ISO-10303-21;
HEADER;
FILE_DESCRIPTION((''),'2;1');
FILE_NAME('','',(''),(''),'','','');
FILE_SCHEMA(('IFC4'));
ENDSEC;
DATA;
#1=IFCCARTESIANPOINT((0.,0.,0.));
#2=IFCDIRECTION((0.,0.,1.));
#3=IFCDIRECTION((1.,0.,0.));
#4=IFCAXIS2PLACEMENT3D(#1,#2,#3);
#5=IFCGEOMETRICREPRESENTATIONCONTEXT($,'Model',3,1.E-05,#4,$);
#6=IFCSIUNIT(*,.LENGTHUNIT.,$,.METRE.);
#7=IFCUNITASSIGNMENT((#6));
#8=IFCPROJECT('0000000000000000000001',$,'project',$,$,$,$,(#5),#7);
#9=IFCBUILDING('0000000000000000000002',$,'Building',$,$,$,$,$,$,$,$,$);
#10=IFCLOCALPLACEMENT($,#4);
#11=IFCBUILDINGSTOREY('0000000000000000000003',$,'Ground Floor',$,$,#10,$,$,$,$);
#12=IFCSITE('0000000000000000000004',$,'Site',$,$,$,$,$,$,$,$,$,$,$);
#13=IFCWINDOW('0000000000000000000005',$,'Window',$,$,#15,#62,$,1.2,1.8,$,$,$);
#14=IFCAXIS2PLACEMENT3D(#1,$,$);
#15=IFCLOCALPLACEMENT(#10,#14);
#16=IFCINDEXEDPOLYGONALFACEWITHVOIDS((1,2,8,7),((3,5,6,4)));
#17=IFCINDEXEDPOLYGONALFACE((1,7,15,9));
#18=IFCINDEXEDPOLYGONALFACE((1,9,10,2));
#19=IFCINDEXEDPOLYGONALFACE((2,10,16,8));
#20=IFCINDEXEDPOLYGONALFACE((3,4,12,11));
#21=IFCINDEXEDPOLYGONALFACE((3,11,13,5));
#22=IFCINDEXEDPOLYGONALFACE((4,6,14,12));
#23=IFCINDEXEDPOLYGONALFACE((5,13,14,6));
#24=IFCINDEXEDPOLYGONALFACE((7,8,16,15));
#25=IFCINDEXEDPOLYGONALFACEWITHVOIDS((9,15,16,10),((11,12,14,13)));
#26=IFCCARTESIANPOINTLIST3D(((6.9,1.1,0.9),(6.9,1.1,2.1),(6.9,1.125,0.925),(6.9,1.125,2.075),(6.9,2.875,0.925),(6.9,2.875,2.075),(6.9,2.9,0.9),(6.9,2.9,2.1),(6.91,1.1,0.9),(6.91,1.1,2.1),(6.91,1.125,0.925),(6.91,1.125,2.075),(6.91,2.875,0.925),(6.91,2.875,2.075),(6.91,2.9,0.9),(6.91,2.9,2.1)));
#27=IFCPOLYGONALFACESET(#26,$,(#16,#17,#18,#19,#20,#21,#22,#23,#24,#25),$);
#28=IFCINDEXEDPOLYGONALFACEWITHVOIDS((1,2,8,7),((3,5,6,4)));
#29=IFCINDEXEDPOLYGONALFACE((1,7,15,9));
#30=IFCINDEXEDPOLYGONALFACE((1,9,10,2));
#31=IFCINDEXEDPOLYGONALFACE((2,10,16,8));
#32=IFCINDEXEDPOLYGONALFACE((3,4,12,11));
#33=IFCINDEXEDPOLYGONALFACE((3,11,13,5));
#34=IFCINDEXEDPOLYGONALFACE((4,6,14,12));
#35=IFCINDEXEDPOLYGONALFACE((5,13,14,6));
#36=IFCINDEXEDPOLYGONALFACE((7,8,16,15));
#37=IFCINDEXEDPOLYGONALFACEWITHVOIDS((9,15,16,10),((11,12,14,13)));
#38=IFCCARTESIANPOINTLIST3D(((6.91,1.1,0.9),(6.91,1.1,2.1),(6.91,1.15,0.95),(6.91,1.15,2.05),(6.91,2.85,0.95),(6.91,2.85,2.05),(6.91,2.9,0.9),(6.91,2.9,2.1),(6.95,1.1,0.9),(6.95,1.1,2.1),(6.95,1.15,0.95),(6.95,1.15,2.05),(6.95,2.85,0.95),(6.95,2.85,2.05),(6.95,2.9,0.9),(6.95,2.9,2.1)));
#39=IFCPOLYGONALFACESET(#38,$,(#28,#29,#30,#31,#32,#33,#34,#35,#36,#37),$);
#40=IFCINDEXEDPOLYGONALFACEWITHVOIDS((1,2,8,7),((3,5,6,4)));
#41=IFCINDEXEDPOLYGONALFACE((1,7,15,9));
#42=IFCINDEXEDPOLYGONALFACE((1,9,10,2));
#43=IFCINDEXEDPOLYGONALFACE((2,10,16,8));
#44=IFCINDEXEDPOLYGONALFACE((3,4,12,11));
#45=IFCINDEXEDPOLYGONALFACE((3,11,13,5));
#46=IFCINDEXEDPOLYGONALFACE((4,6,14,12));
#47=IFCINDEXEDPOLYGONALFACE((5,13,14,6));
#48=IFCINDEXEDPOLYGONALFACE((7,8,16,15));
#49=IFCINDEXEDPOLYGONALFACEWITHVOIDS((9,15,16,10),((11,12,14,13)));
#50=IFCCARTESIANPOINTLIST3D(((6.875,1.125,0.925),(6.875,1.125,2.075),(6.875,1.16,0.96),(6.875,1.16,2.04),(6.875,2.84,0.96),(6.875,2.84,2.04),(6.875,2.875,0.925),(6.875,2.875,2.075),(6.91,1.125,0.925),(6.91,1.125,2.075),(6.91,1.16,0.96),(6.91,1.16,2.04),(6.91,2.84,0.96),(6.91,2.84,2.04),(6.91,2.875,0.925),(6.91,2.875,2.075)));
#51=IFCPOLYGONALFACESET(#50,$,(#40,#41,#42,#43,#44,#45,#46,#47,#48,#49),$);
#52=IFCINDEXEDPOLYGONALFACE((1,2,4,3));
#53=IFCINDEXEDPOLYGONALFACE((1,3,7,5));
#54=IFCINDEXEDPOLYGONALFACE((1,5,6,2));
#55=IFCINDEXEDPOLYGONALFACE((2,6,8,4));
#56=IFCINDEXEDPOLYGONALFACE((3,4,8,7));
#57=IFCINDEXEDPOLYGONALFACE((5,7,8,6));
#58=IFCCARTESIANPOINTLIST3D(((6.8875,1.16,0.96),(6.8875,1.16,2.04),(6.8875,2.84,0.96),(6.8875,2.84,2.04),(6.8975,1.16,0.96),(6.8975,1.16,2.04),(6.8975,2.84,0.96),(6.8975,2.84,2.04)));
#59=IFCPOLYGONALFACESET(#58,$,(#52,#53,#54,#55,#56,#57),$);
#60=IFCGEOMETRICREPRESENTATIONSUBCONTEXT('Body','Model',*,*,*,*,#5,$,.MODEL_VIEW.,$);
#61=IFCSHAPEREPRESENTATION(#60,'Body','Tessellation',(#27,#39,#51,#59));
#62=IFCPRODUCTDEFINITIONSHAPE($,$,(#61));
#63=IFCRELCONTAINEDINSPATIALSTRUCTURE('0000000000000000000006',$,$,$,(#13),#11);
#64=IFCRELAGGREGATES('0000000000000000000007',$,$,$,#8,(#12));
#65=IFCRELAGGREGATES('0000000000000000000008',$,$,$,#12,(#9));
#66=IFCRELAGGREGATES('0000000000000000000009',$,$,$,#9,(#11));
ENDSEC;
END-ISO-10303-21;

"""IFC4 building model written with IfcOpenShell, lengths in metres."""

from ifc_helpers import new_model, si_unit, frame, origin_with_axes, place, context, subcontext, project, spatial, line, indexed_curve, outline, extrude, element, save


model = new_model("IFC4")

# Units and contexts
model_context = context("Model", 3, precision=1e-05, world=origin_with_axes())
body_context = subcontext(model_context, "Body", "Model", "MODEL_VIEW")
ifc_project = project(units=[si_unit("LENGTHUNIT", "METRE")], contexts=[model_context])

# Site, building, storey
site = spatial("IfcSite", under=ifc_project, Name="Site")
building = spatial("IfcBuilding", under=site, Name="Building")
storey_placement = place(None, origin_with_axes())
storey = spatial("IfcBuildingStorey", under=building, at=storey_placement, Name="Ground Floor")

# Window
window_1_placement = place(storey_placement, frame((7.0, 1.1, 0.9), z_axis=(0.0, 0.0, 1.0), x_axis=(0.0, 1.0, 0.0)))
element("IfcWindow", 1, at=window_1_placement, inside=storey, Name="Window", OverallHeight=1.2, OverallWidth=1.8, context=body_context, shape_type="SweptSolid", body=[
    extrude(outline(indexed_curve([(0.0, 0.0), (1.8, 0.0), (1.8, 1.2), (0.0, 1.2)], segments=[line(1, 2, 3, 4, 1)]), holes=[indexed_curve([(0.025, 0.025), (1.775, 0.025), (1.775, 1.175), (0.025, 1.175)], segments=[line(1, 2, 3, 4, 1)])]), frame((0.0, 0.09, 0.0), z_axis=(0.0, -1.0, 0.0), x_axis=(1.0, 0.0, 0.0)), (0.0, 0.0, -1.0), 0.01),
    extrude(outline(indexed_curve([(0.0, 0.0), (1.8, 0.0), (1.8, 1.2), (0.0, 1.2)], segments=[line(1, 2, 3, 4, 1)]), holes=[indexed_curve([(0.05, 0.05), (1.75, 0.05), (1.75, 1.15), (0.05, 1.15)], segments=[line(1, 2, 3, 4, 1)])]), frame((0.0, 0.05, 0.0), z_axis=(0.0, -1.0, 0.0), x_axis=(1.0, 0.0, 0.0)), (0.0, 0.0, -1.0), 0.04),
    extrude(outline(indexed_curve([(0.0, 0.0), (1.75, 0.0), (1.75, 1.15), (0.0, 1.15)], segments=[line(1, 2, 3, 4, 1)]), holes=[indexed_curve([(0.035, 0.035), (1.715, 0.035), (1.715, 1.115), (0.035, 1.115)], segments=[line(1, 2, 3, 4, 1)])]), frame((0.025, 0.09, 0.025), z_axis=(0.0, -1.0, 0.0), x_axis=(1.0, 0.0, 0.0)), (0.0, 0.0, -1.0), 0.035),
    extrude(outline(indexed_curve([(0.035, 0.035), (1.715, 0.035), (1.715, 1.115), (0.035, 1.115)], segments=[line(1, 2, 3, 4, 1)])), frame((0.025, 0.1025, 0.025), z_axis=(0.0, -1.0, 0.0), x_axis=(1.0, 0.0, 0.0)), (0.0, 0.0, -1.0), 0.01),
])

save(model, "model.ifc")
